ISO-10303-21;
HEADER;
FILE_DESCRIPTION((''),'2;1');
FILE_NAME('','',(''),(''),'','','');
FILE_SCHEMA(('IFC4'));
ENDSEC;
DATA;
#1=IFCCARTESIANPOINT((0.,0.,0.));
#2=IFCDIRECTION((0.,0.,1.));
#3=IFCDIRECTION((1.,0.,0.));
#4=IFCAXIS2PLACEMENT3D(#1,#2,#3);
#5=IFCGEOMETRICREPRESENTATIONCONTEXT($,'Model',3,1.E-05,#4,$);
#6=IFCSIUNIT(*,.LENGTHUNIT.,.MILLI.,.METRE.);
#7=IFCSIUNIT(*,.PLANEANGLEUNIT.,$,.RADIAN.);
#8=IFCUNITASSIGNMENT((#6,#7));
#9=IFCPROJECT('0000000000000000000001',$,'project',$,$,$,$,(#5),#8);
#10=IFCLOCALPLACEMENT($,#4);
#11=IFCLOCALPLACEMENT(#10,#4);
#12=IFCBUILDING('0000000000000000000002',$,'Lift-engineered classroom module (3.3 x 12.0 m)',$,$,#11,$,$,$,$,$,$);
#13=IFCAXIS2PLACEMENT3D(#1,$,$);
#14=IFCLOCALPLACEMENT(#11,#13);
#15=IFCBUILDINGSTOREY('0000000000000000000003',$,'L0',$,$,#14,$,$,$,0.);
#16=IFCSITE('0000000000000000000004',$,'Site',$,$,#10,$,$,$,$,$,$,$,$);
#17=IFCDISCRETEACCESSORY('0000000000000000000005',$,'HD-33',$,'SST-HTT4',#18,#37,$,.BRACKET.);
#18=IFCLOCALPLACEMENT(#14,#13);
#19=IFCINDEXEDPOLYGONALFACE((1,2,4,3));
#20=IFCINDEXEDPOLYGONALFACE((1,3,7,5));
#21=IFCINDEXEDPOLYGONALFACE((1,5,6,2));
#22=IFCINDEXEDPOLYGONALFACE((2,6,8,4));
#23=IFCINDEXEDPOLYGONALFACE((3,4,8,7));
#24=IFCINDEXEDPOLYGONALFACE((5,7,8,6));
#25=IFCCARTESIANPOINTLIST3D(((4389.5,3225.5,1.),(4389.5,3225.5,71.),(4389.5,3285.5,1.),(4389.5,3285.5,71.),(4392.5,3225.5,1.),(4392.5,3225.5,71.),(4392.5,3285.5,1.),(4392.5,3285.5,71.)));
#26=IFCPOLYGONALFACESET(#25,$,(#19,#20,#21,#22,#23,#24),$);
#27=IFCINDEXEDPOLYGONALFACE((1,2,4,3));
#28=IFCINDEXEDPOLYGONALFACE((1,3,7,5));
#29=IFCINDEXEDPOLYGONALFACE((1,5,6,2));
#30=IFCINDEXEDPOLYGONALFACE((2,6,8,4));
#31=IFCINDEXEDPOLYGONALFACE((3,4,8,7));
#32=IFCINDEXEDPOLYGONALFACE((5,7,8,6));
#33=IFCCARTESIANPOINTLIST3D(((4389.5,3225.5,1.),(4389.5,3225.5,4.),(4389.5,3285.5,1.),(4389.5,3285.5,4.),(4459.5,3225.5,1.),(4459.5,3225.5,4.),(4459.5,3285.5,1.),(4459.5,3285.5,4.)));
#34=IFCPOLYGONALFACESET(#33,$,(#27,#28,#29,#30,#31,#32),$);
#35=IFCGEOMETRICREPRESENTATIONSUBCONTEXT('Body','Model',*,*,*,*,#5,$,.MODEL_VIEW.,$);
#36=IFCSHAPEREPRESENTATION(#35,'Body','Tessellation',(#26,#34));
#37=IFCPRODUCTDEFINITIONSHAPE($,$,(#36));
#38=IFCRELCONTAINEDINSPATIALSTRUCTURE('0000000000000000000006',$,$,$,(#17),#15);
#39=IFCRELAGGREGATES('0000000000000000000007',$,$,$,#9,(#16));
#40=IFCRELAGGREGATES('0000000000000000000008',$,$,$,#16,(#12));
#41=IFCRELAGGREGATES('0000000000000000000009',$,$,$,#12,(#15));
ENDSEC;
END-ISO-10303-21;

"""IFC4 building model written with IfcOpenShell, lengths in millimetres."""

from ifc_helpers import new_model, si_unit, frame, frame_2d, origin, origin_with_axes, place, context, subcontext, project, spatial, rectangle, extrude, element, save


model = new_model("IFC4")

# Units and contexts
model_context = context("Model", 3, precision=1e-05, world=origin_with_axes())
body_context = subcontext(model_context, "Body", "Model", "MODEL_VIEW")
ifc_project = project(units=[si_unit("LENGTHUNIT", "METRE", prefix="MILLI"), si_unit("PLANEANGLEUNIT", "RADIAN")], contexts=[model_context])

# Site, building, storey
site_placement = place(None, origin_with_axes())
site = spatial("IfcSite", under=ifc_project, at=site_placement, Name="Site")
building_placement = place(site_placement, origin_with_axes())
building = spatial("IfcBuilding", under=site, at=building_placement, Name="Lift-engineered classroom module (3.3 x 12.0 m)")
storey_placement = place(building_placement, origin())
storey = spatial("IfcBuildingStorey", under=building, at=storey_placement, Name="L0", Elevation=0.0)

# Discrete accessory
discrete_accessory_1_placement = place(None, frame((4389.5, 3255.5, 0.0), z_axis=(0.0, 0.0, 1.0), x_axis=(1.0, 0.0, 0.0)))
element("IfcDiscreteAccessory", 1, at=discrete_accessory_1_placement, inside=storey, Name="HD-33", ObjectType="SST-HTT4", PredefinedType="BRACKET", context=body_context, shape_type="SweptSolid", body=[
    extrude(rectangle(XDim=3.0, YDim=60.0, at=frame_2d((1.5, 0.0))), frame((0.0, 0.0, 1.0), z_axis=(0.0, 0.0, 1.0), x_axis=(1.0, 0.0, 0.0)), (0.0, 0.0, 1.0), 70.0),
    extrude(rectangle(XDim=70.0, YDim=60.0, at=frame_2d((35.0, 0.0))), frame((0.0, 0.0, 1.0), z_axis=(0.0, 0.0, 1.0), x_axis=(1.0, 0.0, 0.0)), (0.0, 0.0, 1.0), 3.0),
])

save(model, "model.ifc")
